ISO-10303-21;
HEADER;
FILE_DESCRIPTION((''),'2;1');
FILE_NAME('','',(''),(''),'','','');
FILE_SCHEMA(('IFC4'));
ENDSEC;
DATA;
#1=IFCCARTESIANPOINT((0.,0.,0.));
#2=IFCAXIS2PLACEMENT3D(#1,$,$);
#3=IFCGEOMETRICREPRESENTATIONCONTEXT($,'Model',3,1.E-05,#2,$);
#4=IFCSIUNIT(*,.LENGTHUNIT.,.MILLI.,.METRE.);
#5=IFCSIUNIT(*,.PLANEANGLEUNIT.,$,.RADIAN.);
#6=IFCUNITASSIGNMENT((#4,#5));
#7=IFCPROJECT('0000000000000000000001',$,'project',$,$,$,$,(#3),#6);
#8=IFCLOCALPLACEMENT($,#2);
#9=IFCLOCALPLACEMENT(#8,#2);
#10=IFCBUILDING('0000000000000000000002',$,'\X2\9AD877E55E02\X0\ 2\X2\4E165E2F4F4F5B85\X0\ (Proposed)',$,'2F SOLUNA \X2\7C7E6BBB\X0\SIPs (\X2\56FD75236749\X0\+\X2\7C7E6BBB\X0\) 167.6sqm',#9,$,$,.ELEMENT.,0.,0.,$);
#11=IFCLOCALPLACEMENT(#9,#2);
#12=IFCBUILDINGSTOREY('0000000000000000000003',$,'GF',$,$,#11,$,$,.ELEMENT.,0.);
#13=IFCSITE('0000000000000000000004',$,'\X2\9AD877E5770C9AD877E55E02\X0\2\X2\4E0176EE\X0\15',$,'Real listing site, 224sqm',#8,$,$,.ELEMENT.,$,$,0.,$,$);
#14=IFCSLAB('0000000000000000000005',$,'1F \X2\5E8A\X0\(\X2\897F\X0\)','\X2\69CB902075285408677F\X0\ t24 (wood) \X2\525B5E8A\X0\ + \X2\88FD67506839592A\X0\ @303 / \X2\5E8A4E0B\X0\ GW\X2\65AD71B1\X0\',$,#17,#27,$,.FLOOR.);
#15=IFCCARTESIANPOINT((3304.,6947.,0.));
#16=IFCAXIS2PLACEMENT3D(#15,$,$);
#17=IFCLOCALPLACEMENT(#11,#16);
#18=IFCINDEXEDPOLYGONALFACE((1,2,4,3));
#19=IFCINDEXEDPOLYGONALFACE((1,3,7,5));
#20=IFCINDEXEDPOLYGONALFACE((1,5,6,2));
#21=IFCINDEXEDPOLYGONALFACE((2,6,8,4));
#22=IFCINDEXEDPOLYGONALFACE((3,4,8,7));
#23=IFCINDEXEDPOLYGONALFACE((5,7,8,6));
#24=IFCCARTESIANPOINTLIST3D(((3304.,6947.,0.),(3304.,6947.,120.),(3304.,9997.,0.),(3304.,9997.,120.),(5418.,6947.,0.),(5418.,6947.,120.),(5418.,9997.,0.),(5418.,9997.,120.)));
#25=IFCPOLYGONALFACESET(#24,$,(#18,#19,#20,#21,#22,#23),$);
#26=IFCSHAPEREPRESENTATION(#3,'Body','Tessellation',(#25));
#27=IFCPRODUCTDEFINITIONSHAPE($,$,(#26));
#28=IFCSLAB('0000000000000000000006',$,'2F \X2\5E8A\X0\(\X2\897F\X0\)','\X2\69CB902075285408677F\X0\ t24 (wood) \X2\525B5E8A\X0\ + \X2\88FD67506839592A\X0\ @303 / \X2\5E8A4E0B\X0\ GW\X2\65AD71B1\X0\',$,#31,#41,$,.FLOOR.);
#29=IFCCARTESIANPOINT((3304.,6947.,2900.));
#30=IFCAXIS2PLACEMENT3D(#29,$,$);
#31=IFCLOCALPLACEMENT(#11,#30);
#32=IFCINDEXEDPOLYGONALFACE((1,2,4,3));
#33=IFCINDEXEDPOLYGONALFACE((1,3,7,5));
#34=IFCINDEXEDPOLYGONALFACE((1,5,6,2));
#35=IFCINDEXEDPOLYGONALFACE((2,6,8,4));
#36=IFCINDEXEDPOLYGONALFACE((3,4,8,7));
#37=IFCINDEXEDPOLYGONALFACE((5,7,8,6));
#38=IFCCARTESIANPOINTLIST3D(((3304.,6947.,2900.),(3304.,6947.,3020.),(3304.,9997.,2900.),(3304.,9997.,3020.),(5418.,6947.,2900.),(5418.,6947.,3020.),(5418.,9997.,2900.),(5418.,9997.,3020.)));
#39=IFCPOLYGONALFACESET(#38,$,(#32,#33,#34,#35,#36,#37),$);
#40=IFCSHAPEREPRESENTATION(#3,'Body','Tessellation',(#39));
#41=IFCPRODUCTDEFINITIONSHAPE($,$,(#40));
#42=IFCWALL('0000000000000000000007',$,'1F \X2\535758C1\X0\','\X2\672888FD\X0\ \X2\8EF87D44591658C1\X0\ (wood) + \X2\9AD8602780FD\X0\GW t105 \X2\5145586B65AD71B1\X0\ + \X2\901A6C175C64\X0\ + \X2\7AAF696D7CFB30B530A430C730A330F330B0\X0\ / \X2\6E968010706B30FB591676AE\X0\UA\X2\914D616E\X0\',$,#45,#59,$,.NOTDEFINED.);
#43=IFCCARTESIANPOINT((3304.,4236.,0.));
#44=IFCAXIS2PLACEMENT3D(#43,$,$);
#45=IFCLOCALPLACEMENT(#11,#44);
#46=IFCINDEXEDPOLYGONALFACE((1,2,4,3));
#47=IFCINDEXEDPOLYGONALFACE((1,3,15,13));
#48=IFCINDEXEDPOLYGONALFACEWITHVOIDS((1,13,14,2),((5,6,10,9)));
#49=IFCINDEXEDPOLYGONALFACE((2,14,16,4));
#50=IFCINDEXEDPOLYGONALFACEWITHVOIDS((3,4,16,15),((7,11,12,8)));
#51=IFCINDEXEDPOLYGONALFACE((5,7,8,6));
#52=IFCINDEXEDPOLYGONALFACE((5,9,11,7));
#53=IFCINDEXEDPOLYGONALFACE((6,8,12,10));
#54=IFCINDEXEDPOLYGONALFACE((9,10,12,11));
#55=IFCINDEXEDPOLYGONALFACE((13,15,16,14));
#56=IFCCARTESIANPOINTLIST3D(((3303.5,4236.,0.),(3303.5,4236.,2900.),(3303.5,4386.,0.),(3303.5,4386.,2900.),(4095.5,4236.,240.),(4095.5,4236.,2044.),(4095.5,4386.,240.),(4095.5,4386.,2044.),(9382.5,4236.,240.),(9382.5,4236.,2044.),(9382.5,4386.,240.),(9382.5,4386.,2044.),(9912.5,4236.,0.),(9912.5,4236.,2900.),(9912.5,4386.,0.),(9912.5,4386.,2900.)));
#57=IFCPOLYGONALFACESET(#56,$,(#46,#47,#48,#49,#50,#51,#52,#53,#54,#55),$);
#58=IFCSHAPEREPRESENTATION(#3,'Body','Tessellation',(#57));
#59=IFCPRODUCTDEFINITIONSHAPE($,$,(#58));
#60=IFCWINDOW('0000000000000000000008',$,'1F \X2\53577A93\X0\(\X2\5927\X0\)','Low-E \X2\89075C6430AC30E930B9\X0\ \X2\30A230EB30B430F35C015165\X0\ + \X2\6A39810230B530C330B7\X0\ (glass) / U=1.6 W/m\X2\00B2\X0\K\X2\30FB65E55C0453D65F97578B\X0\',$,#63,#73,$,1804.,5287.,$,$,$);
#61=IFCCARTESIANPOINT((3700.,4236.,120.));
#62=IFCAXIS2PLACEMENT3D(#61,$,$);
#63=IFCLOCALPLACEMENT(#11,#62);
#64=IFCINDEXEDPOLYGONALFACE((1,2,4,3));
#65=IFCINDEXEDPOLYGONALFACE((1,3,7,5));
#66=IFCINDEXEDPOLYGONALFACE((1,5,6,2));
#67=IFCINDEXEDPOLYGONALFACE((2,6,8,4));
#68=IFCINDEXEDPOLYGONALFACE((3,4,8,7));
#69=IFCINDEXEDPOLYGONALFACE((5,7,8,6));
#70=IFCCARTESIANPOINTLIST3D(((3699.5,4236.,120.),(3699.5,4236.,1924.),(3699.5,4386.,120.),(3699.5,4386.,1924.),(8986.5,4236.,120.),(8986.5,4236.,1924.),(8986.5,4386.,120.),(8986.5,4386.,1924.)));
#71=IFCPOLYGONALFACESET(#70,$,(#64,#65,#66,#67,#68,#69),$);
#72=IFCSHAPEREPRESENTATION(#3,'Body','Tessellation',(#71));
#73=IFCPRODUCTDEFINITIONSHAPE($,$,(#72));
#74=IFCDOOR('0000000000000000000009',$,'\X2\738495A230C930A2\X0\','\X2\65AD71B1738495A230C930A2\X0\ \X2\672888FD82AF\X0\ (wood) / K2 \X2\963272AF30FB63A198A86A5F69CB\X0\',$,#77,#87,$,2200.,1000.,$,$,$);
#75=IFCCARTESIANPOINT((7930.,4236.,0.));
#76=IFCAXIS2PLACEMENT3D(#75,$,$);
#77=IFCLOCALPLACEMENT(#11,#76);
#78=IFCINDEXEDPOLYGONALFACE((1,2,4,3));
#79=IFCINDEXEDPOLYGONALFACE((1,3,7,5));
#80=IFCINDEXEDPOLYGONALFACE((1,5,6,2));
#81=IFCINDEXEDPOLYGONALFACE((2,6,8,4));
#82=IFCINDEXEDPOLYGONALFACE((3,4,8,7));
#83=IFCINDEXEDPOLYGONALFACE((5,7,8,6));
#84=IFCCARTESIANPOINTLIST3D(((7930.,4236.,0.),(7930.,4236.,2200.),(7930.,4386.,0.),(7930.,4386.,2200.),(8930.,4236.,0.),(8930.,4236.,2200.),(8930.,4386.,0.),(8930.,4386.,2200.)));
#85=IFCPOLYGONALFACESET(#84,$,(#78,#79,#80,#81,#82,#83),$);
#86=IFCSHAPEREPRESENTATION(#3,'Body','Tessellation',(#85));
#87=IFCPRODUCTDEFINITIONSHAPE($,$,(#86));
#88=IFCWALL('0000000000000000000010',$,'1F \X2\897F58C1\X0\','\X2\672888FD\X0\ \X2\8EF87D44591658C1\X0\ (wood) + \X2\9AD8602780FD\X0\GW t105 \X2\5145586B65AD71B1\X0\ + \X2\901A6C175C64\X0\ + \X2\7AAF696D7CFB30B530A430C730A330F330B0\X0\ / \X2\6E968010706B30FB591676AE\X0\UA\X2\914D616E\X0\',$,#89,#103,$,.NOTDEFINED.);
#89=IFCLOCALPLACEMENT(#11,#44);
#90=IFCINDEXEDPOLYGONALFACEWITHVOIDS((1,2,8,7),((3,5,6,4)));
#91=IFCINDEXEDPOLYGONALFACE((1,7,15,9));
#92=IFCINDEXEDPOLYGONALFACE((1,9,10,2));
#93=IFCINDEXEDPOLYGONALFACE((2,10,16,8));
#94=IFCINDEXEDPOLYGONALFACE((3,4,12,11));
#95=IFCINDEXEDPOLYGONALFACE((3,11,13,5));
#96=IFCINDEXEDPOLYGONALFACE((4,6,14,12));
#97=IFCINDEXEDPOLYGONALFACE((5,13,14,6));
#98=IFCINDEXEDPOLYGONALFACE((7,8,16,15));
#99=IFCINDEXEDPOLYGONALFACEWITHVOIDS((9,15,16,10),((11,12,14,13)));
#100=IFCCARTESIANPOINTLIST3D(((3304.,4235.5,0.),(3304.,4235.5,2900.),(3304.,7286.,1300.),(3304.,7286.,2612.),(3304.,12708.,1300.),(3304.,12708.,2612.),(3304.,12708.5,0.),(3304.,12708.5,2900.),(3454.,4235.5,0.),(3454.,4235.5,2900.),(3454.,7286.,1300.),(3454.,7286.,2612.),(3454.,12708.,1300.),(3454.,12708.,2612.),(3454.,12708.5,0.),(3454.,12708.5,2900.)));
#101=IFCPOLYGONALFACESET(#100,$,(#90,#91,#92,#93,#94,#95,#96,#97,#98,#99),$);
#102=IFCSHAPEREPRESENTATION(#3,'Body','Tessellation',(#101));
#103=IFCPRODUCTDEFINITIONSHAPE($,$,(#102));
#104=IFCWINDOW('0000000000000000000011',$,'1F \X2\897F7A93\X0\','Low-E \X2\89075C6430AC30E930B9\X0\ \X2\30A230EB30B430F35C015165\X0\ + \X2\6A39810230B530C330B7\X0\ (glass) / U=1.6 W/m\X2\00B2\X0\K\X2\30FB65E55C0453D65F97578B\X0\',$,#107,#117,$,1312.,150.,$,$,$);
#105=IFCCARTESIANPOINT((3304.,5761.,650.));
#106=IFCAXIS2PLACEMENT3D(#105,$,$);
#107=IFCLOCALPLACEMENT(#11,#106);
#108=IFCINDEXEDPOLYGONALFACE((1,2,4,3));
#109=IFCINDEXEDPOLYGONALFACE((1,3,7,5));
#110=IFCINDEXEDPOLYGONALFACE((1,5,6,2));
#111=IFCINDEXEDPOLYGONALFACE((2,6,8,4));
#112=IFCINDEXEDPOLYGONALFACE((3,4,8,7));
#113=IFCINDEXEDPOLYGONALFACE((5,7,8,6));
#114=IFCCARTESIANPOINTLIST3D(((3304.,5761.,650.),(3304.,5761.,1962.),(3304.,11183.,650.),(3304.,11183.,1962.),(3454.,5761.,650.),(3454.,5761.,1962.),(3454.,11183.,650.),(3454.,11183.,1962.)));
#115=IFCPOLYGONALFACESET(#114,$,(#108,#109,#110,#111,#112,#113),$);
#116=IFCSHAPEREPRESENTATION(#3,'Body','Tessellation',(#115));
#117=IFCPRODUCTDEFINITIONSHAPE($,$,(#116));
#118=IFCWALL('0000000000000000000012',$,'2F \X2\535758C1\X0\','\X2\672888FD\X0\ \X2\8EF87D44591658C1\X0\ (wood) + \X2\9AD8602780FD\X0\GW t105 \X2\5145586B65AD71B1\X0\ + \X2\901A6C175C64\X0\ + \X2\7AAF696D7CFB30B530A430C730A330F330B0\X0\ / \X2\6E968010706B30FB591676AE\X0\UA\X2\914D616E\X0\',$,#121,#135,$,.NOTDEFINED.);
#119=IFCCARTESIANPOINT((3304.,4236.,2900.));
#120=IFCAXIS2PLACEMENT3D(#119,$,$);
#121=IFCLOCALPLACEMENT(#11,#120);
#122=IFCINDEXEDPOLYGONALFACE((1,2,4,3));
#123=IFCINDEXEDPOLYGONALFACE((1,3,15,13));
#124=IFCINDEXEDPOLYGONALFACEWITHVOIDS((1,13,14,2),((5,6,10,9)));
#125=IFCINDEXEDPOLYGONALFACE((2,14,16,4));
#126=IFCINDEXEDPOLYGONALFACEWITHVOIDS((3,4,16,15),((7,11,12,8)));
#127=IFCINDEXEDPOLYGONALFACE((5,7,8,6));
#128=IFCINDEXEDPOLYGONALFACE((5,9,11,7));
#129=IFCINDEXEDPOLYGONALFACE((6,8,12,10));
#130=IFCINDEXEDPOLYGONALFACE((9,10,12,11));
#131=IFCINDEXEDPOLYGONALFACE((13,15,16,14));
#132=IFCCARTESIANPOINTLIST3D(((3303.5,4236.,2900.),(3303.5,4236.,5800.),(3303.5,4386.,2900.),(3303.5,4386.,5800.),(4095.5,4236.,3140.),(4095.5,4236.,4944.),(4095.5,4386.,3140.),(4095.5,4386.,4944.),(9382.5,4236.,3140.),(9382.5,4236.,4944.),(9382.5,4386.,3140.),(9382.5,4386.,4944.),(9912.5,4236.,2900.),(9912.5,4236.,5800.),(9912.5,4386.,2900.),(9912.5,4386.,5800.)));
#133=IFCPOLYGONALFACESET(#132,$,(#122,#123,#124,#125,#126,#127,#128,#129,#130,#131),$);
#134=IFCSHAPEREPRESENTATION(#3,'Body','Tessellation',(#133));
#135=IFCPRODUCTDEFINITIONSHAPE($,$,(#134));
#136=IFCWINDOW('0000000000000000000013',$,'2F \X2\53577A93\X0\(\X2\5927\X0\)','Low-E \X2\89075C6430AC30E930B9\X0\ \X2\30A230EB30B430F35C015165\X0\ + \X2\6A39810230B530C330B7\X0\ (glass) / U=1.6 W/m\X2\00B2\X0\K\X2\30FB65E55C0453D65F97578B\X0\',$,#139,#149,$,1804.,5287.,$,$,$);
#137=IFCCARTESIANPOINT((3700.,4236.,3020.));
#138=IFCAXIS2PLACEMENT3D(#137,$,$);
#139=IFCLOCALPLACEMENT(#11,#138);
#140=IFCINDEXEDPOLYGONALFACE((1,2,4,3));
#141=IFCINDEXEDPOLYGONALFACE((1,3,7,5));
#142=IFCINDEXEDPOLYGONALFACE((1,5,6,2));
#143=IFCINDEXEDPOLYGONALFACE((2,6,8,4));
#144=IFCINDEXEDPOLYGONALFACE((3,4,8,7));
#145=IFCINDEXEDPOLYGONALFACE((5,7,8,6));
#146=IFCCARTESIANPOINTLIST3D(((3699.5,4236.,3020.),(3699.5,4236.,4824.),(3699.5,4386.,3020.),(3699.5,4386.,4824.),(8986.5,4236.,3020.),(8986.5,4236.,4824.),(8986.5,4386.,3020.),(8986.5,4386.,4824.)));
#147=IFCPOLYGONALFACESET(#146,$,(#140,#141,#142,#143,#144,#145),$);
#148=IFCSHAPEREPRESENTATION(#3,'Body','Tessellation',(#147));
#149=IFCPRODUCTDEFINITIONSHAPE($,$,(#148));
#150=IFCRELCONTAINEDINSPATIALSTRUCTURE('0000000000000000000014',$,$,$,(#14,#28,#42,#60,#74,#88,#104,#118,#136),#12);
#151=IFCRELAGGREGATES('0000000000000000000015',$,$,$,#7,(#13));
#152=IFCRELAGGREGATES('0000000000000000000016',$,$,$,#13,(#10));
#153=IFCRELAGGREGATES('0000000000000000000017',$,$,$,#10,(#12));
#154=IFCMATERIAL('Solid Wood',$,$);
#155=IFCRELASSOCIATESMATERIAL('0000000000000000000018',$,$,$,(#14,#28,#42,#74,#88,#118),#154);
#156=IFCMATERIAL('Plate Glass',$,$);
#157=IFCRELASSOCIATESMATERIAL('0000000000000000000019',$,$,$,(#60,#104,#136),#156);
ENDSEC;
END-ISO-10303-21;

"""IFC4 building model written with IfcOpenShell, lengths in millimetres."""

from ifc_helpers import new_model, si_unit, frame, frame_2d, origin, place, context, project, spatial, rectangle, extrude, material, element, fill, save


model = new_model("IFC4")

# Units and contexts
model_context = context("Model", 3, precision=1e-05, world=origin())
ifc_project = project(units=[si_unit("LENGTHUNIT", "METRE", prefix="MILLI"), si_unit("PLANEANGLEUNIT", "RADIAN")], contexts=[model_context])

# Site, building, storey
site_placement = place(None, origin())
site = spatial("IfcSite", under=ifc_project, at=site_placement, Name="高知県高知市2丁目15", ObjectType="Real listing site, 224sqm", CompositionType="ELEMENT", RefElevation=0.0)
building_placement = place(site_placement, origin())
building = spatial("IfcBuilding", under=site, at=building_placement, Name="高知市 2世帯住宅 (Proposed)", ObjectType="2F SOLUNA 籾殻SIPs (国産杉+籾殻) 167.6sqm", CompositionType="ELEMENT", ElevationOfRefHeight=0.0, ElevationOfTerrain=0.0)
storey_placement = place(building_placement, origin())
storey = spatial("IfcBuildingStorey", under=building, at=storey_placement, Name="GF", CompositionType="ELEMENT", Elevation=0.0)

# Slabs
ifc_material_1 = material(Name="Solid Wood")
slab_1_placement = place(storey_placement, frame((3304.0, 6947.0, 0.0)))
element("IfcSlab", 1, at=slab_1_placement, inside=storey, material=ifc_material_1, Name="1F 床(西)", Description="構造用合板 t24 (wood) 剛床 + 製材根太 @303 / 床下 GW断熱", PredefinedType="FLOOR", context=model_context, shape_type="SweptSolid", body=[
    extrude(rectangle(XDim=2114.0, YDim=3050.0, at=frame_2d((1057.0, 1525.0))), frame((3304.0, 6947.0, 0.0)), (0.0, 0.0, 1.0), 120.0),
])
slab_2_placement = place(storey_placement, frame((3304.0, 6947.0, 2900.0)))
element("IfcSlab", 2, at=slab_2_placement, inside=storey, material=ifc_material_1, Name="2F 床(西)", Description="構造用合板 t24 (wood) 剛床 + 製材根太 @303 / 床下 GW断熱", PredefinedType="FLOOR", context=model_context, shape_type="SweptSolid", body=[
    extrude(rectangle(XDim=2114.0, YDim=3050.0, at=frame_2d((1057.0, 1525.0))), frame((3304.0, 6947.0, 2900.0)), (0.0, 0.0, 1.0), 120.0),
])

# Wall, openings, window, door
wall_1_placement = place(storey_placement, frame((3304.0, 4236.0, 0.0)))
wall_1 = element("IfcWall", 3, at=wall_1_placement, inside=storey, material=ifc_material_1, Name="1F 南壁", Description="木製 軸組外壁 (wood) + 高性能GW t105 充填断熱 + 通気層 + 窯業系サイディング / 準耐火・外皮UA配慮", PredefinedType="NOTDEFINED", context=model_context, shape_type="SweptSolid", body=[
    extrude(rectangle(XDim=6609.0, YDim=150.0, at=frame_2d((3304.0, 75.0))), frame((3304.0, 4236.0, 0.0)), (0.0, 0.0, 1.0), 2900.0),
])
opening_1_placement = place(storey_placement, frame((3700.0, 4236.0, 120.0)))
opening_1 = element("IfcOpeningElement", 4, at=opening_1_placement, cuts=wall_1, PredefinedType="NOTDEFINED", context=model_context, shape_type="SweptSolid", body=[
    extrude(rectangle(XDim=5287.0, YDim=150.0, at=frame_2d((2643.0, 75.0))), frame((3700.0, 4236.0, 120.0)), (0.0, 0.0, 1.0), 1804.0),
])
opening_2_placement = place(storey_placement, frame((7930.0, 4236.0, 0.0)))
opening_2 = element("IfcOpeningElement", 5, at=opening_2_placement, cuts=wall_1, PredefinedType="NOTDEFINED", context=model_context, shape_type="SweptSolid", body=[
    extrude(rectangle(XDim=1000.0, YDim=150.0, at=frame_2d((500.0, 75.0))), frame((7930.0, 4236.0, 0.0)), (0.0, 0.0, 1.0), 2200.0),
])
ifc_material_2 = material(Name="Plate Glass")
window_1_placement = place(storey_placement, frame((3700.0, 4236.0, 120.0)))
window_1 = element("IfcWindow", 6, at=window_1_placement, inside=storey, material=ifc_material_2, Name="1F 南窓(大)", Description="Low-E 複層ガラス アルゴン封入 + 樹脂サッシ (glass) / U=1.6 W/m²K・日射取得型", OverallHeight=1804.0, OverallWidth=5287.0, context=model_context, shape_type="SweptSolid", body=[
    extrude(rectangle(XDim=5287.0, YDim=150.0, at=frame_2d((2643.0, 75.0))), frame((3700.0, 4236.0, 120.0)), (0.0, 0.0, 1.0), 1804.0),
])
fill(opening_1, window_1)
door_placement = place(storey_placement, frame((7930.0, 4236.0, 0.0)))
door = element("IfcDoor", 7, at=door_placement, inside=storey, material=ifc_material_1, Name="玄関ドア", Description="断熱玄関ドア 木製芯 (wood) / K2 防犯・採風機構", OverallHeight=2200.0, OverallWidth=1000.0, context=model_context, shape_type="SweptSolid", body=[
    extrude(rectangle(XDim=1000.0, YDim=150.0, at=frame_2d((500.0, 75.0))), frame((7930.0, 4236.0, 0.0)), (0.0, 0.0, 1.0), 2200.0),
])
fill(opening_2, door)

# Walls, openings, windows
wall_2_placement = place(storey_placement, frame((3304.0, 4236.0, 0.0)))
wall_2 = element("IfcWall", 8, at=wall_2_placement, inside=storey, material=ifc_material_1, Name="1F 西壁", Description="木製 軸組外壁 (wood) + 高性能GW t105 充填断熱 + 通気層 + 窯業系サイディング / 準耐火・外皮UA配慮", PredefinedType="NOTDEFINED", context=model_context, shape_type="SweptSolid", body=[
    extrude(rectangle(XDim=150.0, YDim=8473.0, at=frame_2d((75.0, 4236.0))), frame((3304.0, 4236.0, 0.0)), (0.0, 0.0, 1.0), 2900.0),
])
opening_3_placement = place(storey_placement, frame((3304.0, 5761.0, 650.0)))
opening_3 = element("IfcOpeningElement", 9, at=opening_3_placement, cuts=wall_2, PredefinedType="NOTDEFINED", context=model_context, shape_type="SweptSolid", body=[
    extrude(rectangle(XDim=150.0, YDim=5422.0, at=frame_2d((75.0, 2711.0))), frame((3304.0, 5761.0, 650.0)), (0.0, 0.0, 1.0), 1312.0),
])
window_2_placement = place(storey_placement, frame((3304.0, 5761.0, 650.0)))
window_2 = element("IfcWindow", 10, at=window_2_placement, inside=storey, material=ifc_material_2, Name="1F 西窓", Description="Low-E 複層ガラス アルゴン封入 + 樹脂サッシ (glass) / U=1.6 W/m²K・日射取得型", OverallHeight=1312.0, OverallWidth=150.0, context=model_context, shape_type="SweptSolid", body=[
    extrude(rectangle(XDim=150.0, YDim=5422.0, at=frame_2d((75.0, 2711.0))), frame((3304.0, 5761.0, 650.0)), (0.0, 0.0, 1.0), 1312.0),
])
fill(opening_3, window_2)
wall_3_placement = place(storey_placement, frame((3304.0, 4236.0, 2900.0)))
wall_3 = element("IfcWall", 11, at=wall_3_placement, inside=storey, material=ifc_material_1, Name="2F 南壁", Description="木製 軸組外壁 (wood) + 高性能GW t105 充填断熱 + 通気層 + 窯業系サイディング / 準耐火・外皮UA配慮", PredefinedType="NOTDEFINED", context=model_context, shape_type="SweptSolid", body=[
    extrude(rectangle(XDim=6609.0, YDim=150.0, at=frame_2d((3304.0, 75.0))), frame((3304.0, 4236.0, 2900.0)), (0.0, 0.0, 1.0), 2900.0),
])
opening_4_placement = place(storey_placement, frame((3700.0, 4236.0, 3020.0)))
opening_4 = element("IfcOpeningElement", 12, at=opening_4_placement, cuts=wall_3, PredefinedType="NOTDEFINED", context=model_context, shape_type="SweptSolid", body=[
    extrude(rectangle(XDim=5287.0, YDim=150.0, at=frame_2d((2643.0, 75.0))), frame((3700.0, 4236.0, 3020.0)), (0.0, 0.0, 1.0), 1804.0),
])
window_3_placement = place(storey_placement, frame((3700.0, 4236.0, 3020.0)))
window_3 = element("IfcWindow", 13, at=window_3_placement, inside=storey, material=ifc_material_2, Name="2F 南窓(大)", Description="Low-E 複層ガラス アルゴン封入 + 樹脂サッシ (glass) / U=1.6 W/m²K・日射取得型", OverallHeight=1804.0, OverallWidth=5287.0, context=model_context, shape_type="SweptSolid", body=[
    extrude(rectangle(XDim=5287.0, YDim=150.0, at=frame_2d((2643.0, 75.0))), frame((3700.0, 4236.0, 3020.0)), (0.0, 0.0, 1.0), 1804.0),
])
fill(opening_4, window_3)

save(model, "model.ifc")
